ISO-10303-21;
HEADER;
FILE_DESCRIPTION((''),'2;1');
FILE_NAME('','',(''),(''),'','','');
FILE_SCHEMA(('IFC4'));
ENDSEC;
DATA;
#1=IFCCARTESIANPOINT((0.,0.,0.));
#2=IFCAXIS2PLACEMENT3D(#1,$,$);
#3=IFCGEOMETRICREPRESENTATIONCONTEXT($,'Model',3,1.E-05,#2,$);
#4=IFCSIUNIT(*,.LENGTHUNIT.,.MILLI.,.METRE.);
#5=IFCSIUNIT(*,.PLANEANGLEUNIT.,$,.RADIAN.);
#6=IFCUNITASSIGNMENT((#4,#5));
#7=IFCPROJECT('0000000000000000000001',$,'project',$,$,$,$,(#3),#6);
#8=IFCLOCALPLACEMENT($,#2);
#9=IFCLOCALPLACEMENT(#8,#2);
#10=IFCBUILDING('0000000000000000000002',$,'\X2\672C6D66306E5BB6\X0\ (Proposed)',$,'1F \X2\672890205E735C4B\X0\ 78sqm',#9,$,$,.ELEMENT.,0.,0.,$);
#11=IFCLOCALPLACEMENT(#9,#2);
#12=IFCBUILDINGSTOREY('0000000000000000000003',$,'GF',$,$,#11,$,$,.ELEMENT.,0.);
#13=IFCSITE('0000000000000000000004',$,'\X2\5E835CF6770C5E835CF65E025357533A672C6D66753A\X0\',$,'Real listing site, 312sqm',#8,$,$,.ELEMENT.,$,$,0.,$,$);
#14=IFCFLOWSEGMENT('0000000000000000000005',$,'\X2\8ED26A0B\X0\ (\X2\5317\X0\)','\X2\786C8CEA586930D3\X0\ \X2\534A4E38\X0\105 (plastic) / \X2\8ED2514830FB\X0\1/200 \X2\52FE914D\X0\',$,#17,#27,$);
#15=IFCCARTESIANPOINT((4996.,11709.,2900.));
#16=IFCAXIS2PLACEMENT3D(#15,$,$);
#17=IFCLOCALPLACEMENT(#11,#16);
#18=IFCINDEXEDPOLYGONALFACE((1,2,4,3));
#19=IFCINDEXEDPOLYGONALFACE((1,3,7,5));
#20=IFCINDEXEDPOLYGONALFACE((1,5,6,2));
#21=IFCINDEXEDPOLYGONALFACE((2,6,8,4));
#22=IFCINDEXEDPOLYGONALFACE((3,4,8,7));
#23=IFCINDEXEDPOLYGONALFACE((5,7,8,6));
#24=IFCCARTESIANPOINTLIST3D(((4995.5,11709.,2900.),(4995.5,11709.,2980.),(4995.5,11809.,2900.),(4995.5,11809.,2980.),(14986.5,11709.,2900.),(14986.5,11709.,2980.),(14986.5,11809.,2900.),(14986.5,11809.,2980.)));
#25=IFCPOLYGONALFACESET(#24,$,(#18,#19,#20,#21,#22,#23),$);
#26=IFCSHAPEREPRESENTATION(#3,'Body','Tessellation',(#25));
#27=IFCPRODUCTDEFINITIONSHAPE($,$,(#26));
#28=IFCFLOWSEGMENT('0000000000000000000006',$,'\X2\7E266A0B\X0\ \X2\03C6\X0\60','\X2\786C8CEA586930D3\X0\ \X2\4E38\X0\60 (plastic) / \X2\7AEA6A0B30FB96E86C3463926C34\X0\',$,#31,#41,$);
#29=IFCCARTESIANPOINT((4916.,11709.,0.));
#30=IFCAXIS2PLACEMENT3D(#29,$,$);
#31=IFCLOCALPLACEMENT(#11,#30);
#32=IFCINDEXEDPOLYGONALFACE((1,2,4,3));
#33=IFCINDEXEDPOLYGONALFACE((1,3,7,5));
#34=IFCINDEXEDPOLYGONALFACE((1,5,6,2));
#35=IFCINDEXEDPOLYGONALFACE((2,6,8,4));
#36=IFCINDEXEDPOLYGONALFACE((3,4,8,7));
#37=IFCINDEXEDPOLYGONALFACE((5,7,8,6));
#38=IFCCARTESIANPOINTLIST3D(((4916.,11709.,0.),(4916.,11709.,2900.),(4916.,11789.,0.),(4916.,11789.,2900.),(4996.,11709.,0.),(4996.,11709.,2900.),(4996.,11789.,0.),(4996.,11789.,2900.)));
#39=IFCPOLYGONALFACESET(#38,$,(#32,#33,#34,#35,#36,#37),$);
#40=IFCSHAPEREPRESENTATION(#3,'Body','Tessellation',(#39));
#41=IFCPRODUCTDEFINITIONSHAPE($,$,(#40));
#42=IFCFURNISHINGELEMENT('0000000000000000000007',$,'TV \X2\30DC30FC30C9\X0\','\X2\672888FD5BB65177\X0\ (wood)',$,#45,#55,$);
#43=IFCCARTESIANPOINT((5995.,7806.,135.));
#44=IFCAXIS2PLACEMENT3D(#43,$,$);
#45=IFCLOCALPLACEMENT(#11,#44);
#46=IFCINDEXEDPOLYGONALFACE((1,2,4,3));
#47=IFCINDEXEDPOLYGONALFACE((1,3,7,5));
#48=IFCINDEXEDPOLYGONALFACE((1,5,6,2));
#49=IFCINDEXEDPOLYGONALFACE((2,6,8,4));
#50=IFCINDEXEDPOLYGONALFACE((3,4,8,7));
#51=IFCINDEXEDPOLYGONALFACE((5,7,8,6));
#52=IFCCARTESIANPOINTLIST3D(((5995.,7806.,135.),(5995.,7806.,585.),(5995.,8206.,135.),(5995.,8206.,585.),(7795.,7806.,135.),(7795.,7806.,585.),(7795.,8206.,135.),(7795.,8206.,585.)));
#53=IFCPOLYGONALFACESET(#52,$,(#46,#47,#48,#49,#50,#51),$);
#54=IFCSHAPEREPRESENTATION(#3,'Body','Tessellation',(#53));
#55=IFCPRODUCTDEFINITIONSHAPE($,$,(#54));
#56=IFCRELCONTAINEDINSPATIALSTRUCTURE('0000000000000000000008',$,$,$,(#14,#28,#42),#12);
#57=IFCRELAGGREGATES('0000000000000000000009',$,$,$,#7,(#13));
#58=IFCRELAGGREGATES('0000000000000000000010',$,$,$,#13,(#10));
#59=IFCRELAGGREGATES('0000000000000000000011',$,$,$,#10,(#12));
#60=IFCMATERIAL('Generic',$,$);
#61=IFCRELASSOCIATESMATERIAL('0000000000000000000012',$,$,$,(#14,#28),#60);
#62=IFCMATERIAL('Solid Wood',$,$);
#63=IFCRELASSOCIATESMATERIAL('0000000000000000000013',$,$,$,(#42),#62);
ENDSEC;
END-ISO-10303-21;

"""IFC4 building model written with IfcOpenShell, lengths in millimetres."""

from ifc_helpers import new_model, si_unit, frame, frame_2d, origin, place, context, project, spatial, rectangle, extrude, material, element, save


model = new_model("IFC4")

# Units and contexts
model_context = context("Model", 3, precision=1e-05, world=origin())
ifc_project = project(units=[si_unit("LENGTHUNIT", "METRE", prefix="MILLI"), si_unit("PLANEANGLEUNIT", "RADIAN")], contexts=[model_context])

# Site, building, storey
site_placement = place(None, origin())
site = spatial("IfcSite", under=ifc_project, at=site_placement, Name="広島県広島市南区本浦町", ObjectType="Real listing site, 312sqm", CompositionType="ELEMENT", RefElevation=0.0)
building_placement = place(site_placement, origin())
building = spatial("IfcBuilding", under=site, at=building_placement, Name="本浦の家 (Proposed)", ObjectType="1F 木造平屋 78sqm", CompositionType="ELEMENT", ElevationOfRefHeight=0.0, ElevationOfTerrain=0.0)
storey_placement = place(building_placement, origin())
storey = spatial("IfcBuildingStorey", under=building, at=storey_placement, Name="GF", CompositionType="ELEMENT", Elevation=0.0)

# Shared definitions
ifc_material_1 = material(Name="Solid Wood")

# Shared definitions
ifc_material_2 = material(Name="Generic")

# Flow segments
flow_segment_1_placement = place(storey_placement, frame((4996.0, 11709.0, 2900.0)))
element("IfcFlowSegment", 1, at=flow_segment_1_placement, inside=storey, material=ifc_material_2, Name="軒樋 (北)", Description="硬質塩ビ 半丸105 (plastic) / 軒先・1/200 勾配", context=model_context, shape_type="SweptSolid", body=[
    extrude(rectangle(XDim=9991.0, YDim=100.0, at=frame_2d((4995.0, 50.0))), frame((4996.0, 11709.0, 2900.0)), (0.0, 0.0, 1.0), 80.0),
])
flow_segment_2_placement = place(storey_placement, frame((4916.0, 11709.0, 0.0)))
element("IfcFlowSegment", 2, at=flow_segment_2_placement, inside=storey, material=ifc_material_2, Name="縦樋 φ60", Description="硬質塩ビ 丸60 (plastic) / 竪樋・雨水排水", context=model_context, shape_type="SweptSolid", body=[
    extrude(rectangle(XDim=80.0, YDim=80.0, at=frame_2d((40.0, 40.0))), frame((4916.0, 11709.0, 0.0)), (0.0, 0.0, 1.0), 2900.0),
])

# Furnishing element
furnishing_placement = place(storey_placement, frame((5995.0, 7806.0, 135.0)))
element("IfcFurnishingElement", 3, at=furnishing_placement, inside=storey, material=ifc_material_1, Name="TV ボード", Description="木製家具 (wood)", context=model_context, shape_type="SweptSolid", body=[
    extrude(rectangle(XDim=1800.0, YDim=400.0, at=frame_2d((900.0, 200.0))), frame((5995.0, 7806.0, 135.0)), (0.0, 0.0, 1.0), 450.0),
])

save(model, "model.ifc")
